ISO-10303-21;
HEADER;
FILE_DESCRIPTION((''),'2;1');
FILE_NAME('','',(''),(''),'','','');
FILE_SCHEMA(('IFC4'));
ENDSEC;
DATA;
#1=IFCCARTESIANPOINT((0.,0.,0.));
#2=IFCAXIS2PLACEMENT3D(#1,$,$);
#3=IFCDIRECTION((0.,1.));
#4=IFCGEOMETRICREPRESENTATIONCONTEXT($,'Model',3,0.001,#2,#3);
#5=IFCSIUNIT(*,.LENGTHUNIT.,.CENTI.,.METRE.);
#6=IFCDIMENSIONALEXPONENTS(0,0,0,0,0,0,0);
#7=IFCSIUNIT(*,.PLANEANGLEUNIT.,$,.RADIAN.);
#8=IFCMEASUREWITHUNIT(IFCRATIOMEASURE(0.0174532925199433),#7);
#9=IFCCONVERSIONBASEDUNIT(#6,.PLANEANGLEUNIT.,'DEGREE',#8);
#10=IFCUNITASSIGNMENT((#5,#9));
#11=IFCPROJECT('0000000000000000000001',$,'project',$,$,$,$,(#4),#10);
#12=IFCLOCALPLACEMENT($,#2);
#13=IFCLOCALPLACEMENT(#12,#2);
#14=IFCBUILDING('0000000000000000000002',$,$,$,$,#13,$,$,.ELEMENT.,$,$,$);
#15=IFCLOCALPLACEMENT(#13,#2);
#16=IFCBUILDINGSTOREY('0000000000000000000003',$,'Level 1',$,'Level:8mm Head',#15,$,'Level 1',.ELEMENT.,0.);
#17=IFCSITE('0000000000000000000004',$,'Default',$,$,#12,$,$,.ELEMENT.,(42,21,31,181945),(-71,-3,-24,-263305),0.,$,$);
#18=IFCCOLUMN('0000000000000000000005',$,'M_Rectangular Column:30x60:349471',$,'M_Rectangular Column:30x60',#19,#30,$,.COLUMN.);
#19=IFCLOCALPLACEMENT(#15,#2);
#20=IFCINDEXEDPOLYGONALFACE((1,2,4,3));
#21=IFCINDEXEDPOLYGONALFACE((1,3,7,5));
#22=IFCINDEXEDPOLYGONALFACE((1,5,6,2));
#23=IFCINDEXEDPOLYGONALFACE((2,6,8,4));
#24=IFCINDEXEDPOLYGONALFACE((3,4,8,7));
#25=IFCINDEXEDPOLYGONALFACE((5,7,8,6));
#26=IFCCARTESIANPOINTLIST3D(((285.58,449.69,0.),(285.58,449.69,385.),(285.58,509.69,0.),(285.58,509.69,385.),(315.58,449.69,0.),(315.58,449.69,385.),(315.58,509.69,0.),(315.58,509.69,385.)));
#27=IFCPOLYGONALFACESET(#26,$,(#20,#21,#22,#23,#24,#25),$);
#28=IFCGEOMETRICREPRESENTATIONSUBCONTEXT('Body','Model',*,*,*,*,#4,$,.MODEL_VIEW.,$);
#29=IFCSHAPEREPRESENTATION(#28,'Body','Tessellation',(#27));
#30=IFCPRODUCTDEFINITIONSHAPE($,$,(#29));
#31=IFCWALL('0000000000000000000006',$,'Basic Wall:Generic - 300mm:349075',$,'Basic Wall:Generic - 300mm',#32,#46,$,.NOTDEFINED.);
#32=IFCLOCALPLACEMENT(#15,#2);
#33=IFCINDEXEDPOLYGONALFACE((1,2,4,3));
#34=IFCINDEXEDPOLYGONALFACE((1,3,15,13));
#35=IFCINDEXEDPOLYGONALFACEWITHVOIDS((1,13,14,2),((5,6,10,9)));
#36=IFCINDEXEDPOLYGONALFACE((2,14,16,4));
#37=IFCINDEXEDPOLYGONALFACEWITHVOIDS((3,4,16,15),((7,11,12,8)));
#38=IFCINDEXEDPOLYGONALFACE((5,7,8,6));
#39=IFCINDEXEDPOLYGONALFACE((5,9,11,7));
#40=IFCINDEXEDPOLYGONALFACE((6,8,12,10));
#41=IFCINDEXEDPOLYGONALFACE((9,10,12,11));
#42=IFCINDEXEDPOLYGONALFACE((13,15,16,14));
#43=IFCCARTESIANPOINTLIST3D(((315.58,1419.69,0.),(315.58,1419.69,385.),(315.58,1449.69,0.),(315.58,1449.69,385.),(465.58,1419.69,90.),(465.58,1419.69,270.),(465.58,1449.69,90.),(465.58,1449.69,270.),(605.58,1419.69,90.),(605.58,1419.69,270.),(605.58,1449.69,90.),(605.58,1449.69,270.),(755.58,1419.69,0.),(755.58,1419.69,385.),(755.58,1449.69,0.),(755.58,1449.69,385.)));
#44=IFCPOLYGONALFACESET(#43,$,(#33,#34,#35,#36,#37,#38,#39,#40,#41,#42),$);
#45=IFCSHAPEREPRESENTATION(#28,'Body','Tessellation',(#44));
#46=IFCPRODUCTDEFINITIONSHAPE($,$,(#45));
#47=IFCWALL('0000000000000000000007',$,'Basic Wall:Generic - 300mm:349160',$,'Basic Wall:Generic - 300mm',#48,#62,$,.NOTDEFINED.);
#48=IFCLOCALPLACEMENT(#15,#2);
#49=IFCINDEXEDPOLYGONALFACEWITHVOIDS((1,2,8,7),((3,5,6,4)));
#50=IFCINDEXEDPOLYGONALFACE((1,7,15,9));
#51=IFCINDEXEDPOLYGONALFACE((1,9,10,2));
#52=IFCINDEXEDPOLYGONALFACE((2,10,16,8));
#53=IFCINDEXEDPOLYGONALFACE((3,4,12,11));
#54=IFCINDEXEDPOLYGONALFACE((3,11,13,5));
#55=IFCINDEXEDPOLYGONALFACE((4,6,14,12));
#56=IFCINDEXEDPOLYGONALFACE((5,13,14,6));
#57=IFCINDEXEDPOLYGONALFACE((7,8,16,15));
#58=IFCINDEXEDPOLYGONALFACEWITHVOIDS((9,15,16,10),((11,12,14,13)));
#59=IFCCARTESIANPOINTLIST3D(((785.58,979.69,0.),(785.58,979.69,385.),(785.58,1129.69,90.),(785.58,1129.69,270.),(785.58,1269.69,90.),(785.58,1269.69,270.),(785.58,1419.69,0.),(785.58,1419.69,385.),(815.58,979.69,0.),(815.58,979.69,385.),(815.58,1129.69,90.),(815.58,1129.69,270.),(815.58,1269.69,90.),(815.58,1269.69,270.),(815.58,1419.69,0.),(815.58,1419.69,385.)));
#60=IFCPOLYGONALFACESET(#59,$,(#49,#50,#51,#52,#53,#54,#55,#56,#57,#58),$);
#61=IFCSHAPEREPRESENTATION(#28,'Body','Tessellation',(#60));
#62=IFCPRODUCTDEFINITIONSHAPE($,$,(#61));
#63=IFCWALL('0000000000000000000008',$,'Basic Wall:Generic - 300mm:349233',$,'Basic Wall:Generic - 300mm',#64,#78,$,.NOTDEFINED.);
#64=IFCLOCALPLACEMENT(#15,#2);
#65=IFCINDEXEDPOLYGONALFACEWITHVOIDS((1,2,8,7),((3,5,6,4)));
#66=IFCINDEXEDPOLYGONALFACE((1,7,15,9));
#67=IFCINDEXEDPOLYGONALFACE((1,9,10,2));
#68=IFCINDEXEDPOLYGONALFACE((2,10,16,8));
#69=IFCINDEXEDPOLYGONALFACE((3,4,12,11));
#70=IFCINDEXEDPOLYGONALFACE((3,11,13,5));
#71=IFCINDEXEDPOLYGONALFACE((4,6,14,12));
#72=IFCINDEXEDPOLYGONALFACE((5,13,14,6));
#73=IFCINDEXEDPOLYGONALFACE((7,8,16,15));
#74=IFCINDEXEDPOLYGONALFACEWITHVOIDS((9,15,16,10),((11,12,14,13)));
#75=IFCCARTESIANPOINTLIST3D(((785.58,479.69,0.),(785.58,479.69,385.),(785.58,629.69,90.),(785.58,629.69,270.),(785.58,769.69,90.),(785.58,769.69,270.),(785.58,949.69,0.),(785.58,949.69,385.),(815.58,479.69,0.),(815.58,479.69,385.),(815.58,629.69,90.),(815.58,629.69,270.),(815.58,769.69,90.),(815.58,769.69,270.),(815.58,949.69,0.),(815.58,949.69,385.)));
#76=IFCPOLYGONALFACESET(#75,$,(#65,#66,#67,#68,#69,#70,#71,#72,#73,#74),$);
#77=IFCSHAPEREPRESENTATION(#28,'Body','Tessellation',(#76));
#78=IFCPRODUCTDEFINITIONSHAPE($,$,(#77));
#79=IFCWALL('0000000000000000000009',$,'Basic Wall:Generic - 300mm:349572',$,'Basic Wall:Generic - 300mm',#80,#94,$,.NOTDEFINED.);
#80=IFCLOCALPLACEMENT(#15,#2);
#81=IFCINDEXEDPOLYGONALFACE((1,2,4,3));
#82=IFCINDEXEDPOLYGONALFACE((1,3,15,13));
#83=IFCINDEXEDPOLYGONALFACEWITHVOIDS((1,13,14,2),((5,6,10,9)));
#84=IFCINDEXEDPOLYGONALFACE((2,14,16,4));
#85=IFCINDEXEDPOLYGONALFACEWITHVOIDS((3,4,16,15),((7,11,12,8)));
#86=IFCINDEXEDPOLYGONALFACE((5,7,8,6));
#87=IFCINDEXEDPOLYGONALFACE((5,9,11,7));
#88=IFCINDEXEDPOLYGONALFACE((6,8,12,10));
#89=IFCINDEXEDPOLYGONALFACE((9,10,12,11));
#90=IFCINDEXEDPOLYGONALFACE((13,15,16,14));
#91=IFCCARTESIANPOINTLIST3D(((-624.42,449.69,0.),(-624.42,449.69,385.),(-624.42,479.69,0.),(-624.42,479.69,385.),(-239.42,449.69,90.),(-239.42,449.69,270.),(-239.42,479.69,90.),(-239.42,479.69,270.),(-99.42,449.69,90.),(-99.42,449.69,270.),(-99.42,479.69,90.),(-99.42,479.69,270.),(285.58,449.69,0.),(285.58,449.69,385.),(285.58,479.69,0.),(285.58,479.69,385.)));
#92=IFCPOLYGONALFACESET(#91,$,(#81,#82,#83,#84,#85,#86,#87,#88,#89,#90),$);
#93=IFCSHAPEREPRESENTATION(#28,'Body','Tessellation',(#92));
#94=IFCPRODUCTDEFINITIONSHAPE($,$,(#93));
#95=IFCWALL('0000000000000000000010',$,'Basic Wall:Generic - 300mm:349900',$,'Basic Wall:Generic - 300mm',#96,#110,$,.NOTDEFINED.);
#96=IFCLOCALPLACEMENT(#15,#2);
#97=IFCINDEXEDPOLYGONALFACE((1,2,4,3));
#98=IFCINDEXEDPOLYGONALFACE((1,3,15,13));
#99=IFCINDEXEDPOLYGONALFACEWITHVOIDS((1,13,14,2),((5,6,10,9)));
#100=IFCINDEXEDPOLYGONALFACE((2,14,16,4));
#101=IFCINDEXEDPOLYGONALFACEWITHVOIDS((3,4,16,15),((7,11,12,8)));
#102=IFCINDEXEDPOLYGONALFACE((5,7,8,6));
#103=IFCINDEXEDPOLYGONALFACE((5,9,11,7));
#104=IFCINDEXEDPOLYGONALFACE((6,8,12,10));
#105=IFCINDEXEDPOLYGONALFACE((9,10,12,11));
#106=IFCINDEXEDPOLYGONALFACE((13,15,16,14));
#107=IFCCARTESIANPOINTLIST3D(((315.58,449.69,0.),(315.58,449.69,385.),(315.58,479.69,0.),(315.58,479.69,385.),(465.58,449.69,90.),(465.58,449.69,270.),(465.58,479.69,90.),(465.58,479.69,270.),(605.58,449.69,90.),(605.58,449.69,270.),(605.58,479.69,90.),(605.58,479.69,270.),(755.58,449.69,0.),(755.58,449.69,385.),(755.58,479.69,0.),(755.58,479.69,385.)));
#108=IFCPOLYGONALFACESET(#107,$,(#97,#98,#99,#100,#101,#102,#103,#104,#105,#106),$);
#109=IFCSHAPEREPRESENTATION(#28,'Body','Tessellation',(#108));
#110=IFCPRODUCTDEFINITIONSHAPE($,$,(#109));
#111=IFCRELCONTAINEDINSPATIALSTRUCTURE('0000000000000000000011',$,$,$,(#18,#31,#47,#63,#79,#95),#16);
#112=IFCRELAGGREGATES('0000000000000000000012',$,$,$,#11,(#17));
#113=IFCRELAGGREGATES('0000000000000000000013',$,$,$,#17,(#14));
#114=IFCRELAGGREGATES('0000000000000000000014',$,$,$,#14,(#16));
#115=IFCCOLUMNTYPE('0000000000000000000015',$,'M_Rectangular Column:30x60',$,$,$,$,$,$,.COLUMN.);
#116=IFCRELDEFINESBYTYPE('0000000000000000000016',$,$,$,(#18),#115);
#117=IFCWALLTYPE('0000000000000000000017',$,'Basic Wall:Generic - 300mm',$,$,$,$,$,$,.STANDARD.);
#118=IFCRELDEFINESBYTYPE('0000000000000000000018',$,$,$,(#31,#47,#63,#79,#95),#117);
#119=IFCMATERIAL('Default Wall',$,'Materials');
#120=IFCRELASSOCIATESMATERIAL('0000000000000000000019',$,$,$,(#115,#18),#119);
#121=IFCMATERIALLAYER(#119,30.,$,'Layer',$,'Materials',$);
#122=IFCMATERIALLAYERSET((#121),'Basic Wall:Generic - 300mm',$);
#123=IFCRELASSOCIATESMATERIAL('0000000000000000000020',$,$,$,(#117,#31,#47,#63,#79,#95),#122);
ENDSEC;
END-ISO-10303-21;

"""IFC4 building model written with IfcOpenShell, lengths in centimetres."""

from ifc_helpers import new_model, entity, si_unit, converted_unit, direction, frame, frame_2d, origin, place, context, subcontext, project, spatial, polyline, rectangle, extrude, clip, bounded_halfspace, source, transform, mapped, material, layer, layer_set, layer_usage, material_profile, profile_set, profile_usage, type_object, type_shapes, element, save


model = new_model("IFC4")

# Units and contexts
model_context = context("Model", 3, precision=0.001, world=origin(), true_north=direction((0.0, 1.0)))
body_context = subcontext(model_context, "Body", "Model", "MODEL_VIEW")
ifc_project = project(units=[si_unit("LENGTHUNIT", "METRE", prefix="CENTI"), converted_unit("PLANEANGLEUNIT", "DEGREE", entity("IfcRatioMeasure", 0.0174532925199433), si_unit("PLANEANGLEUNIT", "RADIAN"), dimensions=[0, 0, 0, 0, 0, 0, 0])], contexts=[model_context])

# Site, building, storey
site_placement = place(None, origin())
site = spatial("IfcSite", under=ifc_project, at=site_placement, Name="Default", CompositionType="ELEMENT", RefLatitude=(42, 21, 31, 181945), RefLongitude=(-71, -3, -24, -263305), RefElevation=0.0)
building_placement = place(site_placement, origin())
building = spatial("IfcBuilding", under=site, at=building_placement, CompositionType="ELEMENT")
storey_placement = place(building_placement, origin())
storey = spatial("IfcBuildingStorey", under=building, at=storey_placement, Name="Level 1", ObjectType="Level:8mm Head", LongName="Level 1", CompositionType="ELEMENT", Elevation=0.0)

# Column
ifc_material_1 = material(Name="Default Wall", Category="Materials")
ifc_material_profile = material_profile(ifc_material_1, rectangle(XDim=30.0, YDim=60.0, at=frame_2d((0.0, 0.0), x_axis=(1.0, 0.0))), Name="30x60")
ifc_profile_set = profile_set([ifc_material_profile], Name="30x60")
ifc_profile_usage = profile_usage(ifc_profile_set)
column_type = type_object("IfcColumnType", Name="M_Rectangular Column:30x60", PredefinedType="COLUMN", material=ifc_profile_set)
shared_shape_1 = source(origin(), body_context, "Body", "SweptSolid", [
    extrude(rectangle(XDim=60.0, YDim=30.0, at=frame_2d((0.0, 0.0), x_axis=(1.0, 0.0))), frame((300.58, 479.69, 0.0), z_axis=(0.0, 0.0, 1.0), x_axis=(0.0, -1.0, 0.0)), (0.0, 0.0, 1.0), 385.0),
])
type_shapes(column_type, [shared_shape_1])
column_placement = place(storey_placement, origin())
element("IfcColumn", 1, at=column_placement, inside=storey, type_object=column_type, material=ifc_profile_usage, Name="M_Rectangular Column:30x60:349471", ObjectType="M_Rectangular Column:30x60", PredefinedType="COLUMN", context=body_context, shape_type="MappedRepresentation", body=[
    mapped(shared_shape_1, transform((0.0, 0.0, 0.0), scale=1.0)),
])

# Walls, openings
ifc_layer_1 = layer(ifc_material_1, 30.0, Name="Layer", Category="Materials")
ifc_layer_set_1 = layer_set([ifc_layer_1], Name="Basic Wall:Generic - 300mm")
ifc_layer_usage_1 = layer_usage(ifc_layer_set_1, "AXIS2", "NEGATIVE", 15.0)
wall_type_1 = type_object("IfcWallType", Name="Basic Wall:Generic - 300mm", PredefinedType="STANDARD", material=ifc_layer_set_1)
wall_1_placement = place(storey_placement, frame((315.58, 1434.69, 0.0)))
wall_1 = element("IfcWall", 2, at=wall_1_placement, inside=storey, type_object=wall_type_1, material=ifc_layer_usage_1, Name="Basic Wall:Generic - 300mm:349075", ObjectType="Basic Wall:Generic - 300mm", PredefinedType="NOTDEFINED", context=body_context, shape_type="Clipping", body=[
    clip(extrude(rectangle(XDim=440.0, YDim=30.0, at=frame_2d((220.0, 0.0), x_axis=(-1.0, 0.0))), origin(), (0.0, 0.0, 1.0), 385.0), bounded_halfspace(frame((0.0, -15.0, 385.0), z_axis=(0.0, 0.0, -1.0), x_axis=(1.0, 0.0, 0.0)), True, frame((0.0, -15.0, 385.0)), polyline([(0.0, 0.0), (440.0, 0.0), (440.0, 30.0), (0.0, 30.0), (0.0, 0.0)]))),
])
opening_1_placement = place(wall_1_placement, frame((290.0, 15.0, 90.0)))
element("IfcOpeningElement", 3, at=opening_1_placement, cuts=wall_1, PredefinedType="OPENING", context=body_context, shape_type="SweptSolid", body=[
    extrude(rectangle(XDim=180.0, YDim=140.0, at=frame_2d((90.0, 70.0), x_axis=(-1.0, 0.0))), frame((0.0, 0.0, 0.0), z_axis=(0.0, -1.0, 0.0), x_axis=(0.0, 0.0, 1.0)), (0.0, 0.0, 1.0), 30.0),
])
ifc_layer_usage_2 = layer_usage(ifc_layer_set_1, "AXIS2", "NEGATIVE", 15.0)
wall_2_placement = place(storey_placement, frame((800.58, 1419.69, 0.0), z_axis=(0.0, 0.0, 1.0), x_axis=(0.0, -1.0, 0.0)))
wall_2 = element("IfcWall", 4, at=wall_2_placement, inside=storey, type_object=wall_type_1, material=ifc_layer_usage_2, Name="Basic Wall:Generic - 300mm:349160", ObjectType="Basic Wall:Generic - 300mm", PredefinedType="NOTDEFINED", context=body_context, shape_type="Clipping", body=[
    clip(extrude(rectangle(XDim=440.0, YDim=30.0, at=frame_2d((220.0, 0.0), x_axis=(-1.0, 0.0))), origin(), (0.0, 0.0, 1.0), 385.0), bounded_halfspace(frame((0.0, -15.0, 385.0), z_axis=(0.0, 0.0, -1.0), x_axis=(0.0, 1.0, 0.0)), True, frame((0.0, -15.0, 385.0)), polyline([(0.0, 0.0), (440.0, 0.0), (440.0, 30.0), (0.0, 30.0), (0.0, 0.0)]))),
])
opening_2_placement = place(wall_2_placement, frame((290.0, 15.0, 90.0)))
element("IfcOpeningElement", 5, at=opening_2_placement, cuts=wall_2, PredefinedType="OPENING", context=body_context, shape_type="SweptSolid", body=[
    extrude(rectangle(XDim=180.0, YDim=140.0, at=frame_2d((90.0, 70.0), x_axis=(-1.0, 0.0))), frame((0.0, 0.0, 0.0), z_axis=(0.0, -1.0, 0.0), x_axis=(0.0, 0.0, 1.0)), (0.0, 0.0, 1.0), 30.0),
])
ifc_layer_usage_3 = layer_usage(ifc_layer_set_1, "AXIS2", "NEGATIVE", 15.0)
wall_3_placement = place(storey_placement, frame((800.58, 949.69, 0.0), z_axis=(0.0, 0.0, 1.0), x_axis=(0.0, -1.0, 0.0)))
wall_3 = element("IfcWall", 6, at=wall_3_placement, inside=storey, type_object=wall_type_1, material=ifc_layer_usage_3, Name="Basic Wall:Generic - 300mm:349233", ObjectType="Basic Wall:Generic - 300mm", PredefinedType="NOTDEFINED", context=body_context, shape_type="Clipping", body=[
    clip(extrude(rectangle(XDim=470.0, YDim=30.0, at=frame_2d((235.0, 0.0), x_axis=(-1.0, 0.0))), origin(), (0.0, 0.0, 1.0), 385.0), bounded_halfspace(frame((0.0, -15.0, 385.0), z_axis=(0.0, 0.0, -1.0), x_axis=(0.0, 1.0, 0.0)), True, frame((0.0, -15.0, 385.0)), polyline([(0.0, 0.0), (30.0, 0.0), (470.0, 0.0), (470.0, 30.0), (0.0, 30.0), (0.0, 0.0)]))),
])
opening_3_placement = place(wall_3_placement, frame((320.0, 15.0, 90.0)))
element("IfcOpeningElement", 7, at=opening_3_placement, cuts=wall_3, PredefinedType="OPENING", context=body_context, shape_type="SweptSolid", body=[
    extrude(rectangle(XDim=180.0, YDim=140.0, at=frame_2d((90.0, 70.0), x_axis=(-1.0, 0.0))), frame((0.0, 0.0, 0.0), z_axis=(0.0, -1.0, 0.0), x_axis=(0.0, 0.0, 1.0)), (0.0, 0.0, 1.0), 30.0),
])
ifc_layer_usage_4 = layer_usage(ifc_layer_set_1, "AXIS2", "NEGATIVE", 15.0)
wall_4_placement = place(storey_placement, frame((285.58, 464.69, 0.0), z_axis=(0.0, 0.0, 1.0), x_axis=(-1.0, 0.0, 0.0)))
wall_4 = element("IfcWall", 8, at=wall_4_placement, inside=storey, type_object=wall_type_1, material=ifc_layer_usage_4, Name="Basic Wall:Generic - 300mm:349572", ObjectType="Basic Wall:Generic - 300mm", PredefinedType="NOTDEFINED", context=body_context, shape_type="Clipping", body=[
    clip(extrude(rectangle(XDim=910.0, YDim=30.0, at=frame_2d((455.0, 0.0), x_axis=(-1.0, 0.0))), origin(), (0.0, 0.0, 1.0), 385.0), bounded_halfspace(frame((0.0, -15.0, 385.0), z_axis=(0.0, 0.0, -1.0), x_axis=(-1.0, 0.0, 0.0)), True, frame((0.0, -15.0, 385.0)), polyline([(0.0, 0.0), (910.0, 0.0), (910.0, 30.0), (0.0, 30.0), (0.0, 0.0)]))),
])
opening_4_placement = place(wall_4_placement, frame((525.0, 15.0, 90.0)))
element("IfcOpeningElement", 9, at=opening_4_placement, cuts=wall_4, PredefinedType="OPENING", context=body_context, shape_type="SweptSolid", body=[
    extrude(rectangle(XDim=180.0, YDim=140.0, at=frame_2d((90.0, 70.0), x_axis=(-1.0, 0.0))), frame((0.0, 0.0, 0.0), z_axis=(0.0, -1.0, 0.0), x_axis=(0.0, 0.0, 1.0)), (0.0, 0.0, 1.0), 30.0),
])
ifc_layer_usage_5 = layer_usage(ifc_layer_set_1, "AXIS2", "NEGATIVE", 15.0)
wall_5_placement = place(storey_placement, frame((315.58, 464.69, 0.0)))
wall_5 = element("IfcWall", 10, at=wall_5_placement, inside=storey, type_object=wall_type_1, material=ifc_layer_usage_5, Name="Basic Wall:Generic - 300mm:349900", ObjectType="Basic Wall:Generic - 300mm", PredefinedType="NOTDEFINED", context=body_context, shape_type="Clipping", body=[
    clip(extrude(rectangle(XDim=440.0, YDim=30.0, at=frame_2d((220.0, 0.0), x_axis=(-1.0, 0.0))), origin(), (0.0, 0.0, 1.0), 385.0), bounded_halfspace(frame((0.0, -15.0, 385.0), z_axis=(0.0, 0.0, -1.0), x_axis=(1.0, 0.0, 0.0)), True, frame((0.0, -15.0, 385.0)), polyline([(0.0, 0.0), (440.0, 0.0), (440.0, 30.0), (0.0, 30.0), (0.0, 0.0)]))),
])
opening_5_placement = place(wall_5_placement, frame((290.0, 15.0, 90.0)))
element("IfcOpeningElement", 11, at=opening_5_placement, cuts=wall_5, PredefinedType="OPENING", context=body_context, shape_type="SweptSolid", body=[
    extrude(rectangle(XDim=180.0, YDim=140.0, at=frame_2d((90.0, 70.0), x_axis=(-1.0, 0.0))), frame((0.0, 0.0, 0.0), z_axis=(0.0, -1.0, 0.0), x_axis=(0.0, 0.0, 1.0)), (0.0, 0.0, 1.0), 30.0),
])

save(model, "model.ifc")
